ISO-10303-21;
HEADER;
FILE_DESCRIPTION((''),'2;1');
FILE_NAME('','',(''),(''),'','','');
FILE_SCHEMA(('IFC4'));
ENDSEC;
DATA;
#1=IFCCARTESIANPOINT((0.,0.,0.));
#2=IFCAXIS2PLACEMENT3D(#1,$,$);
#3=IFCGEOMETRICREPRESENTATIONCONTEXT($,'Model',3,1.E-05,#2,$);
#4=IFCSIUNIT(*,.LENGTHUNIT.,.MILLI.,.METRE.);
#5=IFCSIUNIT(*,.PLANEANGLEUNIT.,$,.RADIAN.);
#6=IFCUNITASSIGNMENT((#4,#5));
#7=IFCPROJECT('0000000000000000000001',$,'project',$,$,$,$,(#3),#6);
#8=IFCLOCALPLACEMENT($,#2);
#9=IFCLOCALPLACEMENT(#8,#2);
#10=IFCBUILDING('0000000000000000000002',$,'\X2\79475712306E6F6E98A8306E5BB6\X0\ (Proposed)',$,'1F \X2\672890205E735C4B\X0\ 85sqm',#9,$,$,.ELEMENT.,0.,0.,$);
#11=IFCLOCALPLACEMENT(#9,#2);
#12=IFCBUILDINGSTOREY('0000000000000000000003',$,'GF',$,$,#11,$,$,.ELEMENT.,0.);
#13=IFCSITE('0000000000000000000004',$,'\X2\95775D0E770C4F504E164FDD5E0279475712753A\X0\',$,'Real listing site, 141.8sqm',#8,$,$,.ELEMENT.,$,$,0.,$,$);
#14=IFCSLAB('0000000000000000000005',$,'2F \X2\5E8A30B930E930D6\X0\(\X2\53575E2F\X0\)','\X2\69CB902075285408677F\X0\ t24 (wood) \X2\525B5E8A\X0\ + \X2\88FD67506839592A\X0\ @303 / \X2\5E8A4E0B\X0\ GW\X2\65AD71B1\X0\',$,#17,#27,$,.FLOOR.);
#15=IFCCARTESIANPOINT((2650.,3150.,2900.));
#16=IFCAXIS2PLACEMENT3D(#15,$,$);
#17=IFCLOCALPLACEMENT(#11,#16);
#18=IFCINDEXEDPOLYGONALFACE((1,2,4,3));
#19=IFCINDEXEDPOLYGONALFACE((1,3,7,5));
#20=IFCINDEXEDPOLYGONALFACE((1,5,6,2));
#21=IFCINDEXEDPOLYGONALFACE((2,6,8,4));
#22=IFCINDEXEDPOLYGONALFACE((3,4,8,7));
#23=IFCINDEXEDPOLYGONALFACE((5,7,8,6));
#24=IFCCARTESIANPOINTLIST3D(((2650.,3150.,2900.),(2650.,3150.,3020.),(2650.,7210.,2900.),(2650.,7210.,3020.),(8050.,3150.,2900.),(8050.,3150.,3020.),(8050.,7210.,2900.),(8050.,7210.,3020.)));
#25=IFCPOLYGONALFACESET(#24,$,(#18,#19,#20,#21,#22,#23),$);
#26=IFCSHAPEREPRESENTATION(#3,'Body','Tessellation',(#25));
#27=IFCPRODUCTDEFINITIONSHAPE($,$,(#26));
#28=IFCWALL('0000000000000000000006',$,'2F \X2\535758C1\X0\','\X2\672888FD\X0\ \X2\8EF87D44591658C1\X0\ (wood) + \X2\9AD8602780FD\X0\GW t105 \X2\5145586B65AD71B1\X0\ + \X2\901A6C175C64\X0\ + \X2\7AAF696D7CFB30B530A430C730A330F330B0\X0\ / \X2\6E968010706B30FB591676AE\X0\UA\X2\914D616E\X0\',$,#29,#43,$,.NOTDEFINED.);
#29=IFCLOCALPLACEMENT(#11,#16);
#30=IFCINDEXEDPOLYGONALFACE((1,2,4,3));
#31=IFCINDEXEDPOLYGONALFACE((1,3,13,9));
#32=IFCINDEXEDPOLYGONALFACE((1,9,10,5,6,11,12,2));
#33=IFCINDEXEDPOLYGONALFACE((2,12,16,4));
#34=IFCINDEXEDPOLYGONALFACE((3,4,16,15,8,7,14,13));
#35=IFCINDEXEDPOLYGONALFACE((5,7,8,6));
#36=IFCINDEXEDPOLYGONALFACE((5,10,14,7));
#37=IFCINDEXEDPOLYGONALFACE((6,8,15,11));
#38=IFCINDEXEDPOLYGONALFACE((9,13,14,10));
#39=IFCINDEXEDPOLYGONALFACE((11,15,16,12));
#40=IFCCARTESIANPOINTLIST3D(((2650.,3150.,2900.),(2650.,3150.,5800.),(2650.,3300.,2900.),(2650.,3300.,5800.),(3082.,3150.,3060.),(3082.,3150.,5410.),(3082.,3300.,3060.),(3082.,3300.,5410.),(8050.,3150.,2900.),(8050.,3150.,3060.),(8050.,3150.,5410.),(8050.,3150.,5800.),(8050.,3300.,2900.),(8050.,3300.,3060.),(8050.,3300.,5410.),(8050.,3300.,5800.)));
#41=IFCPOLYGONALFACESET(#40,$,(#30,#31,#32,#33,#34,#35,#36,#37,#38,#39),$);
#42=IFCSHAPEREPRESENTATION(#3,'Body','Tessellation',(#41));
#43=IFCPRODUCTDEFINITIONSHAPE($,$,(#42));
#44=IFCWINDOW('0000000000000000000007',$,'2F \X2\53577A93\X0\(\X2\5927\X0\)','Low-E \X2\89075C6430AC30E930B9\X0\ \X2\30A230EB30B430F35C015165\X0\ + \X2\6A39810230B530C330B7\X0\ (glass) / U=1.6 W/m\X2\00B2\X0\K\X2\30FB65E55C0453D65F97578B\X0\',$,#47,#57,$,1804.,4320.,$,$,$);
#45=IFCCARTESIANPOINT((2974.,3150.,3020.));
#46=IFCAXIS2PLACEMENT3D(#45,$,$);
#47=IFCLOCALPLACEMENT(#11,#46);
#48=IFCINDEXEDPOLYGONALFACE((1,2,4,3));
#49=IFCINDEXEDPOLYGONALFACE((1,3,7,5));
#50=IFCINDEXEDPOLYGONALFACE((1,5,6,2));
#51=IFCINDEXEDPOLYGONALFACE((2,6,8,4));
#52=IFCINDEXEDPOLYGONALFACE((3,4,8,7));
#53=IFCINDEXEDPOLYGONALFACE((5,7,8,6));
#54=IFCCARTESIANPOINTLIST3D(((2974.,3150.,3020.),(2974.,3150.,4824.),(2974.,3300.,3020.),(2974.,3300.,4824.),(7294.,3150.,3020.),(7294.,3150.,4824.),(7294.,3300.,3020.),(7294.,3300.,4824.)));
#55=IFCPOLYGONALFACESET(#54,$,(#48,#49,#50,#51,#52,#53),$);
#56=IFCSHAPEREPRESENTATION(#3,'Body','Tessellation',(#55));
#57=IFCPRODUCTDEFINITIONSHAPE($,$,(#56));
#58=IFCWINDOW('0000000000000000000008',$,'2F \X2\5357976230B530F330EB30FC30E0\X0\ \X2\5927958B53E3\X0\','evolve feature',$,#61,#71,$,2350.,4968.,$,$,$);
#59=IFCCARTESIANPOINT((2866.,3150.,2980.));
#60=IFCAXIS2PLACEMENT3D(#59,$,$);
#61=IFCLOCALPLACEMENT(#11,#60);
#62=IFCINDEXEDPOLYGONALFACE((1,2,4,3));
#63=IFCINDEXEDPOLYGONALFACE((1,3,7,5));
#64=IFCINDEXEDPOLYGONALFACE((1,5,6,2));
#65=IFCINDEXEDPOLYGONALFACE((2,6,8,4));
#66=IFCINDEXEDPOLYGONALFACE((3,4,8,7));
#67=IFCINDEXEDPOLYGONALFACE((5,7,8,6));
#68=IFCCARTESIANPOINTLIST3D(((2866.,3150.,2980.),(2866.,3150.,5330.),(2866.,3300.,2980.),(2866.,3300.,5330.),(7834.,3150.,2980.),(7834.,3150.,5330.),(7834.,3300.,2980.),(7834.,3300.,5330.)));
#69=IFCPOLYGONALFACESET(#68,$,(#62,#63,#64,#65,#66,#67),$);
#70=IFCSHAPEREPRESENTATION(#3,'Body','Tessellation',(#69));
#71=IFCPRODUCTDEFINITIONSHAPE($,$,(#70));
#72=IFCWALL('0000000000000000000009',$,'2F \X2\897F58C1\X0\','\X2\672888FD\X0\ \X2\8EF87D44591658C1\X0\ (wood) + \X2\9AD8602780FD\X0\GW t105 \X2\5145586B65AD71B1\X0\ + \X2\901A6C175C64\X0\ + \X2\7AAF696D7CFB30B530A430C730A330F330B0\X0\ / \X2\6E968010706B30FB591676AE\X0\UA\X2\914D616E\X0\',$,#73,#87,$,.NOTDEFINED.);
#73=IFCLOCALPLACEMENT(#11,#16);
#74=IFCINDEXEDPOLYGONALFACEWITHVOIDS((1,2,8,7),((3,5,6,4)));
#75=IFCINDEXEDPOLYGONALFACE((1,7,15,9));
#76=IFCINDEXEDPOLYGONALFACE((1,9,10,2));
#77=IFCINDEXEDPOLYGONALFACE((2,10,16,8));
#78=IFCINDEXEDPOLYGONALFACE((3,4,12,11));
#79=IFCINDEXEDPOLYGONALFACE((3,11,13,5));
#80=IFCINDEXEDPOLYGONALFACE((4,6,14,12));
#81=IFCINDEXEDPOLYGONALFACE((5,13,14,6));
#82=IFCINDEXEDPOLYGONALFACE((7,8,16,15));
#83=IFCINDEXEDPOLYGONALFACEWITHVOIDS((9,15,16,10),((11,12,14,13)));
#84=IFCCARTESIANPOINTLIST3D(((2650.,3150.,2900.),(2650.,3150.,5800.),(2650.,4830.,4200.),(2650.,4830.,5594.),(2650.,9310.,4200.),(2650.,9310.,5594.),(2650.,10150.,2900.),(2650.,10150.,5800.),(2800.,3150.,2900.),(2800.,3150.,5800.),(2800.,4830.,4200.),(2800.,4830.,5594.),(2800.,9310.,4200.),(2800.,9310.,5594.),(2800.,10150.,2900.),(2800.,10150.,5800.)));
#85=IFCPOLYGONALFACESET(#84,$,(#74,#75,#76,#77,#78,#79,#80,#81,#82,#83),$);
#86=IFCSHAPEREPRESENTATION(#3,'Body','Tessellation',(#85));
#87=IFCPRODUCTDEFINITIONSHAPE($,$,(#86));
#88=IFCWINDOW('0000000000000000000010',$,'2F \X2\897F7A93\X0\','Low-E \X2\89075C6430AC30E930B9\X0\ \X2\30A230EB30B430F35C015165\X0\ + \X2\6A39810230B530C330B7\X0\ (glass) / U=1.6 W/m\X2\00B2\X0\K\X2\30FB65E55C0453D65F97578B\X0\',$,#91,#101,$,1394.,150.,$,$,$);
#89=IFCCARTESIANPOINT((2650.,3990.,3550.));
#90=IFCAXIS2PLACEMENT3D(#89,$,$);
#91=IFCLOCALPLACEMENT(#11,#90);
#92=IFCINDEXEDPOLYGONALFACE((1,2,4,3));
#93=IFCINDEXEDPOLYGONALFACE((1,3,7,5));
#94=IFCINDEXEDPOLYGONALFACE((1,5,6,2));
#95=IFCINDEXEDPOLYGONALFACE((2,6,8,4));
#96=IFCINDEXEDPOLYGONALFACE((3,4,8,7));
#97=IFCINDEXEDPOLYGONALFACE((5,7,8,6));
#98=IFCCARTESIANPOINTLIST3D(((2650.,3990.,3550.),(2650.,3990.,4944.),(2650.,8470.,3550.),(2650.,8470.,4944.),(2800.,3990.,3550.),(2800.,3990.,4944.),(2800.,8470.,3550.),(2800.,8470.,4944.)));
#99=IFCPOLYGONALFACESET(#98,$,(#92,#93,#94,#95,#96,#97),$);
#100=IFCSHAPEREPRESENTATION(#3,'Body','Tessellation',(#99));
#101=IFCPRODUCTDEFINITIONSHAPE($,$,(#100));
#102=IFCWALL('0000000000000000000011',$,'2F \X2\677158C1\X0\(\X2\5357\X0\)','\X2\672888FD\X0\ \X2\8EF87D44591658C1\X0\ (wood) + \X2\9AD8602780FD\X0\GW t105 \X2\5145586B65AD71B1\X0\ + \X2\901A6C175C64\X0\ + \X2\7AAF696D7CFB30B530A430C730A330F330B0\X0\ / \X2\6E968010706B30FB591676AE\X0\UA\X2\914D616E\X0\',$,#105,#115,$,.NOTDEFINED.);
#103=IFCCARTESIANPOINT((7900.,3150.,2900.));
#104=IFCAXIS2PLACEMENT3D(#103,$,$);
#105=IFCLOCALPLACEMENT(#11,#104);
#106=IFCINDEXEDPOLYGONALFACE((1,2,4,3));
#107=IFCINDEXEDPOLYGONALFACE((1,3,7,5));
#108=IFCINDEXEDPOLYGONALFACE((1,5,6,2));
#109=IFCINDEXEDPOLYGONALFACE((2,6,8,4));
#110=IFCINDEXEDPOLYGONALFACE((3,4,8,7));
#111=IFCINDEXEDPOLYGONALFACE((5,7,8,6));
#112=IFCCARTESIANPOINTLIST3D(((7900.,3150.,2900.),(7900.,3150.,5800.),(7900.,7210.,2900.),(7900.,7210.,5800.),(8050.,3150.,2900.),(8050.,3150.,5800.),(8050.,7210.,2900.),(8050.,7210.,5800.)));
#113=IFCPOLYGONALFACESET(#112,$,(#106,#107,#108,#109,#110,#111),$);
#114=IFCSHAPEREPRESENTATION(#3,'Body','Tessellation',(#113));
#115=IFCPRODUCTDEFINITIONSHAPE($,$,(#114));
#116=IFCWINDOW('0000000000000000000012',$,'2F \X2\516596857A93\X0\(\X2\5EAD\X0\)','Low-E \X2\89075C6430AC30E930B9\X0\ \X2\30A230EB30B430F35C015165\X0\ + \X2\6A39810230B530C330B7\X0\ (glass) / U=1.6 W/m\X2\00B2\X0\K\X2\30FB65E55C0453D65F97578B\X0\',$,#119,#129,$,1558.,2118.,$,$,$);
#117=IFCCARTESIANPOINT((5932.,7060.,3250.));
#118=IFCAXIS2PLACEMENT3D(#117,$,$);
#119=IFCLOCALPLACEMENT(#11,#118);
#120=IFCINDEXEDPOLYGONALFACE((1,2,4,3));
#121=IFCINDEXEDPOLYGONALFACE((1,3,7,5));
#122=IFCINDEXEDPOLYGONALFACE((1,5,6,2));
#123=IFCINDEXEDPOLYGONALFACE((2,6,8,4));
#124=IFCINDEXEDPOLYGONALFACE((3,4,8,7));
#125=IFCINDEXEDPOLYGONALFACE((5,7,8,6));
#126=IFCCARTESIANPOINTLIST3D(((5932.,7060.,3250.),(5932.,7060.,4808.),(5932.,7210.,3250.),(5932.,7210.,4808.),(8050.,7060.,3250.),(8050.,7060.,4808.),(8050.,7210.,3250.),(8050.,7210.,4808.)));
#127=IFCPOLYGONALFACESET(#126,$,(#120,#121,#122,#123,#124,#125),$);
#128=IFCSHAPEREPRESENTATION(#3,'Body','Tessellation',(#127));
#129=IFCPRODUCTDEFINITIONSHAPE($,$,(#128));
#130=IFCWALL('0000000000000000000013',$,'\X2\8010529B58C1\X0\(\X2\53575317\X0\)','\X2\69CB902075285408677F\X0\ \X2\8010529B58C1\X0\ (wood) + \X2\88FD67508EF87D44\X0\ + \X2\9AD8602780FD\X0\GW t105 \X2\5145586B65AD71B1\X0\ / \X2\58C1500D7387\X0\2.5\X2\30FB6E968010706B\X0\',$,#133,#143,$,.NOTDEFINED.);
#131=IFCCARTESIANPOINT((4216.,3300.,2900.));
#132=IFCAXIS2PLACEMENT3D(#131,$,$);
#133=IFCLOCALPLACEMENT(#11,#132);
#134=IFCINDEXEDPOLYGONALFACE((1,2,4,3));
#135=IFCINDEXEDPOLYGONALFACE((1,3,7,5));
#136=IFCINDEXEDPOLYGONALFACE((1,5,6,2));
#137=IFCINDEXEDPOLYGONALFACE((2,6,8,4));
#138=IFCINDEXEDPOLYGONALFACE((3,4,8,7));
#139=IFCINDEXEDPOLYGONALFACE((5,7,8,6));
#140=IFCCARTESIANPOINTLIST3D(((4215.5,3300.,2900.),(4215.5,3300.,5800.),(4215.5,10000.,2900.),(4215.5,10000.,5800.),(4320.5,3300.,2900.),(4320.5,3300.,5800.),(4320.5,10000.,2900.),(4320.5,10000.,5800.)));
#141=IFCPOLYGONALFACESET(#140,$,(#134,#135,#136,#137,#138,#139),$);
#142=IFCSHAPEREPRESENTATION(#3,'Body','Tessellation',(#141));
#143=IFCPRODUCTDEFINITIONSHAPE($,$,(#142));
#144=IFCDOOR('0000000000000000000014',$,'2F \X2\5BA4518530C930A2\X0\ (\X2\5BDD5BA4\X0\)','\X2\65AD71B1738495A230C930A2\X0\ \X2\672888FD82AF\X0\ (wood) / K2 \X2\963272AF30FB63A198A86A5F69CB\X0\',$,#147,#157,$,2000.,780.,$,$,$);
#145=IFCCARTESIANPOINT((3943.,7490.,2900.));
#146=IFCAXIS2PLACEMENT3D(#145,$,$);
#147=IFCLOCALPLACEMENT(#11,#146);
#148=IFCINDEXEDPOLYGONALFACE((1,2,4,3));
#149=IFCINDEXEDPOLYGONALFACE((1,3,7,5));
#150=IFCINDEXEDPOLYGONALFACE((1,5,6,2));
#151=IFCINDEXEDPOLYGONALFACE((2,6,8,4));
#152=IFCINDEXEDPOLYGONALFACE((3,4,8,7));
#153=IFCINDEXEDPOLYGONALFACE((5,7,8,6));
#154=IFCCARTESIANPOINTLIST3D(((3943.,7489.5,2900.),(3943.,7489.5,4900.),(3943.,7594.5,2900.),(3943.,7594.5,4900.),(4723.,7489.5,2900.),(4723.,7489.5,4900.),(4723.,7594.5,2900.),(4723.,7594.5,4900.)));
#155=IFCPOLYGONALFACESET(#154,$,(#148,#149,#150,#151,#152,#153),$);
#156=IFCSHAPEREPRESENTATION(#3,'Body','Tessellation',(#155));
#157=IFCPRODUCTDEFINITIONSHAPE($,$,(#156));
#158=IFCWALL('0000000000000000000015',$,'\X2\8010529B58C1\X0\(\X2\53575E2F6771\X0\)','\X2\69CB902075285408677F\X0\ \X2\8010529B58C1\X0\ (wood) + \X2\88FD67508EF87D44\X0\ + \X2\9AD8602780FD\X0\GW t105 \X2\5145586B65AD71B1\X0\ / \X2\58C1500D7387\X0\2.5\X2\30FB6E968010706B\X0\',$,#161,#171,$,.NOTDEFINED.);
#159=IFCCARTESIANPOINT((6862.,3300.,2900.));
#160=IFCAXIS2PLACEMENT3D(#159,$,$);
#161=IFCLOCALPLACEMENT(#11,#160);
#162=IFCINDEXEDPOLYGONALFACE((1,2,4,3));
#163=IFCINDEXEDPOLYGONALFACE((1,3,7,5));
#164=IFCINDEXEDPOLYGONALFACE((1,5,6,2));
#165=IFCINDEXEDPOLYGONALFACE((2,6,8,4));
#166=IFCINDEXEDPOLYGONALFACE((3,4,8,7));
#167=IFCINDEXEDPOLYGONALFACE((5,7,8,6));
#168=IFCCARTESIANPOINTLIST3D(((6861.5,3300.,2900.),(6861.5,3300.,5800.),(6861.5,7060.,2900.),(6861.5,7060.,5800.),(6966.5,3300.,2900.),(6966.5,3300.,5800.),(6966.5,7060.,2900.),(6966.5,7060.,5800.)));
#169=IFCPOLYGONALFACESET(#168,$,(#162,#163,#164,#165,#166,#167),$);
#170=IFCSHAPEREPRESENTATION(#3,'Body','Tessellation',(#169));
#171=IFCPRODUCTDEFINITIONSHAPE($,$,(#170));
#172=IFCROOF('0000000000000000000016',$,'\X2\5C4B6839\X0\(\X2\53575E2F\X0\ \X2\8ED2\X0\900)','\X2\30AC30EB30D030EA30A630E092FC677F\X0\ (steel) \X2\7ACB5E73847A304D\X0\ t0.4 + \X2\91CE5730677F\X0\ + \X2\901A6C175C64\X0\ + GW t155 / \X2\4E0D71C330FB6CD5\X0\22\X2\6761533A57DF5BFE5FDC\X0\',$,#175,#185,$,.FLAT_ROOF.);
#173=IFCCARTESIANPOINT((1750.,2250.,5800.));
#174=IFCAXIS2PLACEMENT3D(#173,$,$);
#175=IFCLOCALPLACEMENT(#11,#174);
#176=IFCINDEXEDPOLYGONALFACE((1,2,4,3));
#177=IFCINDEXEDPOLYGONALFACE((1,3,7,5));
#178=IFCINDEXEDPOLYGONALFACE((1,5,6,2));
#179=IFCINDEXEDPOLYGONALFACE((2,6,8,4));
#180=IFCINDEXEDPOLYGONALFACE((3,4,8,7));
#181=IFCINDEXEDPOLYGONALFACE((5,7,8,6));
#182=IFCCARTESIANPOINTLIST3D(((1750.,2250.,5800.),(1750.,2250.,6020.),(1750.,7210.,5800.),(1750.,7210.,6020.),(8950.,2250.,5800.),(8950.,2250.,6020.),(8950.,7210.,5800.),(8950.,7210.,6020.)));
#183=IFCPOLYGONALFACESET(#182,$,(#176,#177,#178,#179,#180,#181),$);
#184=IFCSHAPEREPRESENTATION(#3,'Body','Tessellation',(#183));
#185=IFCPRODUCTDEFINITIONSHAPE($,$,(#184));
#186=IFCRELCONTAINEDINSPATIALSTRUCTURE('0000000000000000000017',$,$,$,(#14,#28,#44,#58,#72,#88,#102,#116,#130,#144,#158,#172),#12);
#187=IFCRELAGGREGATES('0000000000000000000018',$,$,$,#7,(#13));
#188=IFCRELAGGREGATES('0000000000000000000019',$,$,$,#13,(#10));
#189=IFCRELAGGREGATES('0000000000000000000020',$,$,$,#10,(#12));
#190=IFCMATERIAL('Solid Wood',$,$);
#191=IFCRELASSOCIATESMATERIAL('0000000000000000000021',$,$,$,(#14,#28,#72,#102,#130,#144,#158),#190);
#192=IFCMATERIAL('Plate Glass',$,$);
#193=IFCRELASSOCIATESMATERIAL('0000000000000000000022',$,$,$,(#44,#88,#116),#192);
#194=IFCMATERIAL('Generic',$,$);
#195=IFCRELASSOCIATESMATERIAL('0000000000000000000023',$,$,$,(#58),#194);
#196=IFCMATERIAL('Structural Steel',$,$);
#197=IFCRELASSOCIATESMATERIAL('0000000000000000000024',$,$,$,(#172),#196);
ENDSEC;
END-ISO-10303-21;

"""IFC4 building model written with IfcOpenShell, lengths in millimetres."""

from ifc_helpers import new_model, si_unit, frame, frame_2d, origin, place, context, project, spatial, rectangle, extrude, material, element, fill, save


model = new_model("IFC4")

# Units and contexts
model_context = context("Model", 3, precision=1e-05, world=origin())
ifc_project = project(units=[si_unit("LENGTHUNIT", "METRE", prefix="MILLI"), si_unit("PLANEANGLEUNIT", "RADIAN")], contexts=[model_context])

# Site, building, storey
site_placement = place(None, origin())
site = spatial("IfcSite", under=ifc_project, at=site_placement, Name="長崎県佐世保市祇園町", ObjectType="Real listing site, 141.8sqm", CompositionType="ELEMENT", RefElevation=0.0)
building_placement = place(site_placement, origin())
building = spatial("IfcBuilding", under=site, at=building_placement, Name="祇園の潮風の家 (Proposed)", ObjectType="1F 木造平屋 85sqm", CompositionType="ELEMENT", ElevationOfRefHeight=0.0, ElevationOfTerrain=0.0)
storey_placement = place(building_placement, origin())
storey = spatial("IfcBuildingStorey", under=building, at=storey_placement, Name="GF", CompositionType="ELEMENT", Elevation=0.0)

# Slab
ifc_material_1 = material(Name="Solid Wood")
slab_placement = place(storey_placement, frame((2650.0, 3150.0, 2900.0)))
element("IfcSlab", 1, at=slab_placement, inside=storey, material=ifc_material_1, Name="2F 床スラブ(南帯)", Description="構造用合板 t24 (wood) 剛床 + 製材根太 @303 / 床下 GW断熱", PredefinedType="FLOOR", context=model_context, shape_type="SweptSolid", body=[
    extrude(rectangle(XDim=5400.0, YDim=4060.0, at=frame_2d((2700.0, 2030.0))), frame((2650.0, 3150.0, 2900.0)), (0.0, 0.0, 1.0), 120.0),
])

# Wall, openings, windows
wall_1_placement = place(storey_placement, frame((2650.0, 3150.0, 2900.0)))
wall_1 = element("IfcWall", 2, at=wall_1_placement, inside=storey, material=ifc_material_1, Name="2F 南壁", Description="木製 軸組外壁 (wood) + 高性能GW t105 充填断熱 + 通気層 + 窯業系サイディング / 準耐火・外皮UA配慮", PredefinedType="NOTDEFINED", context=model_context, shape_type="SweptSolid", body=[
    extrude(rectangle(XDim=5400.0, YDim=150.0, at=frame_2d((2700.0, 75.0))), frame((2650.0, 3150.0, 2900.0)), (0.0, 0.0, 1.0), 2900.0),
])
opening_1_placement = place(storey_placement, frame((2974.0, 3150.0, 3020.0)))
opening_1 = element("IfcOpeningElement", 3, at=opening_1_placement, cuts=wall_1, PredefinedType="NOTDEFINED", context=model_context, shape_type="SweptSolid", body=[
    extrude(rectangle(XDim=4320.0, YDim=150.0, at=frame_2d((2160.0, 75.0))), frame((2974.0, 3150.0, 3020.0)), (0.0, 0.0, 1.0), 1804.0),
])
opening_2_placement = place(storey_placement, frame((2866.0, 3150.0, 2980.0)))
opening_2 = element("IfcOpeningElement", 4, at=opening_2_placement, cuts=wall_1, PredefinedType="NOTDEFINED", context=model_context, shape_type="SweptSolid", body=[
    extrude(rectangle(XDim=4968.0, YDim=150.0, at=frame_2d((2484.0, 75.0))), frame((2866.0, 3150.0, 2980.0)), (0.0, 0.0, 1.0), 2350.0),
])
ifc_material_2 = material(Name="Plate Glass")
window_1_placement = place(storey_placement, frame((2974.0, 3150.0, 3020.0)))
window_1 = element("IfcWindow", 5, at=window_1_placement, inside=storey, material=ifc_material_2, Name="2F 南窓(大)", Description="Low-E 複層ガラス アルゴン封入 + 樹脂サッシ (glass) / U=1.6 W/m²K・日射取得型", OverallHeight=1804.0, OverallWidth=4320.0, context=model_context, shape_type="SweptSolid", body=[
    extrude(rectangle(XDim=4320.0, YDim=150.0, at=frame_2d((2160.0, 75.0))), frame((2974.0, 3150.0, 3020.0)), (0.0, 0.0, 1.0), 1804.0),
])
fill(opening_1, window_1)
ifc_material_3 = material(Name="Generic")
window_2_placement = place(storey_placement, frame((2866.0, 3150.0, 2980.0)))
window_2 = element("IfcWindow", 6, at=window_2_placement, inside=storey, material=ifc_material_3, Name="2F 南面サンルーム 大開口", Description="evolve feature", OverallHeight=2350.0, OverallWidth=4968.0, context=model_context, shape_type="SweptSolid", body=[
    extrude(rectangle(XDim=4968.0, YDim=150.0, at=frame_2d((2484.0, 75.0))), frame((2866.0, 3150.0, 2980.0)), (0.0, 0.0, 1.0), 2350.0),
])
fill(opening_2, window_2)

# Walls, openings, windows
wall_2_placement = place(storey_placement, frame((2650.0, 3150.0, 2900.0)))
wall_2 = element("IfcWall", 7, at=wall_2_placement, inside=storey, material=ifc_material_1, Name="2F 西壁", Description="木製 軸組外壁 (wood) + 高性能GW t105 充填断熱 + 通気層 + 窯業系サイディング / 準耐火・外皮UA配慮", PredefinedType="NOTDEFINED", context=model_context, shape_type="SweptSolid", body=[
    extrude(rectangle(XDim=150.0, YDim=7000.0, at=frame_2d((75.0, 3500.0))), frame((2650.0, 3150.0, 2900.0)), (0.0, 0.0, 1.0), 2900.0),
])
opening_3_placement = place(storey_placement, frame((2650.0, 3990.0, 3550.0)))
opening_3 = element("IfcOpeningElement", 8, at=opening_3_placement, cuts=wall_2, PredefinedType="NOTDEFINED", context=model_context, shape_type="SweptSolid", body=[
    extrude(rectangle(XDim=150.0, YDim=4480.0, at=frame_2d((75.0, 2240.0))), frame((2650.0, 3990.0, 3550.0)), (0.0, 0.0, 1.0), 1394.0),
])
window_3_placement = place(storey_placement, frame((2650.0, 3990.0, 3550.0)))
window_3 = element("IfcWindow", 9, at=window_3_placement, inside=storey, material=ifc_material_2, Name="2F 西窓", Description="Low-E 複層ガラス アルゴン封入 + 樹脂サッシ (glass) / U=1.6 W/m²K・日射取得型", OverallHeight=1394.0, OverallWidth=150.0, context=model_context, shape_type="SweptSolid", body=[
    extrude(rectangle(XDim=150.0, YDim=4480.0, at=frame_2d((75.0, 2240.0))), frame((2650.0, 3990.0, 3550.0)), (0.0, 0.0, 1.0), 1394.0),
])
fill(opening_3, window_3)
wall_3_placement = place(storey_placement, frame((7900.0, 3150.0, 2900.0)))
wall_3 = element("IfcWall", 10, at=wall_3_placement, inside=storey, material=ifc_material_1, Name="2F 東壁(南)", Description="木製 軸組外壁 (wood) + 高性能GW t105 充填断熱 + 通気層 + 窯業系サイディング / 準耐火・外皮UA配慮", PredefinedType="NOTDEFINED", context=model_context, shape_type="SweptSolid", body=[
    extrude(rectangle(XDim=150.0, YDim=4060.0, at=frame_2d((75.0, 2030.0))), frame((7900.0, 3150.0, 2900.0)), (0.0, 0.0, 1.0), 2900.0),
])
opening_4_placement = place(storey_placement, frame((5932.0, 7060.0, 3250.0)))
opening_4 = element("IfcOpeningElement", 11, at=opening_4_placement, cuts=wall_3, PredefinedType="NOTDEFINED", context=model_context, shape_type="SweptSolid", body=[
    extrude(rectangle(XDim=2118.0, YDim=150.0, at=frame_2d((1059.0, 75.0))), frame((5932.0, 7060.0, 3250.0)), (0.0, 0.0, 1.0), 1558.0),
])
window_4_placement = place(storey_placement, frame((5932.0, 7060.0, 3250.0)))
window_4 = element("IfcWindow", 12, at=window_4_placement, inside=storey, material=ifc_material_2, Name="2F 入隅窓(庭)", Description="Low-E 複層ガラス アルゴン封入 + 樹脂サッシ (glass) / U=1.6 W/m²K・日射取得型", OverallHeight=1558.0, OverallWidth=2118.0, context=model_context, shape_type="SweptSolid", body=[
    extrude(rectangle(XDim=2118.0, YDim=150.0, at=frame_2d((1059.0, 75.0))), frame((5932.0, 7060.0, 3250.0)), (0.0, 0.0, 1.0), 1558.0),
])
fill(opening_4, window_4)

# Wall, opening, door
wall_4_placement = place(storey_placement, frame((4216.0, 3300.0, 2900.0)))
wall_4 = element("IfcWall", 13, at=wall_4_placement, inside=storey, material=ifc_material_1, Name="耐力壁(南北)", Description="構造用合板 耐力壁 (wood) + 製材軸組 + 高性能GW t105 充填断熱 / 壁倍率2.5・準耐火", PredefinedType="NOTDEFINED", context=model_context, shape_type="SweptSolid", body=[
    extrude(rectangle(XDim=105.0, YDim=6700.0, at=frame_2d((52.0, 3350.0))), frame((4216.0, 3300.0, 2900.0)), (0.0, 0.0, 1.0), 2900.0),
])
opening_5_placement = place(storey_placement, frame((3943.0, 7490.0, 2900.0)))
opening_5 = element("IfcOpeningElement", 14, at=opening_5_placement, cuts=wall_4, PredefinedType="NOTDEFINED", context=model_context, shape_type="SweptSolid", body=[
    extrude(rectangle(XDim=780.0, YDim=105.0, at=frame_2d((390.0, 52.0))), frame((3943.0, 7490.0, 2900.0)), (0.0, 0.0, 1.0), 2000.0),
])
door_placement = place(storey_placement, frame((3943.0, 7490.0, 2900.0)))
door = element("IfcDoor", 15, at=door_placement, inside=storey, material=ifc_material_1, Name="2F 室内ドア (寝室)", Description="断熱玄関ドア 木製芯 (wood) / K2 防犯・採風機構", OverallHeight=2000.0, OverallWidth=780.0, context=model_context, shape_type="SweptSolid", body=[
    extrude(rectangle(XDim=780.0, YDim=105.0, at=frame_2d((390.0, 52.0))), frame((3943.0, 7490.0, 2900.0)), (0.0, 0.0, 1.0), 2000.0),
])
fill(opening_5, door)

# Wall
wall_5_placement = place(storey_placement, frame((6862.0, 3300.0, 2900.0)))
element("IfcWall", 16, at=wall_5_placement, inside=storey, material=ifc_material_1, Name="耐力壁(南帯東)", Description="構造用合板 耐力壁 (wood) + 製材軸組 + 高性能GW t105 充填断熱 / 壁倍率2.5・準耐火", PredefinedType="NOTDEFINED", context=model_context, shape_type="SweptSolid", body=[
    extrude(rectangle(XDim=105.0, YDim=3760.0, at=frame_2d((52.0, 1880.0))), frame((6862.0, 3300.0, 2900.0)), (0.0, 0.0, 1.0), 2900.0),
])

# Roof
ifc_material_4 = material(Name="Structural Steel")
for number, where, name in (
    (17, (1750.0, 2250.0, 5800.0), "屋根(南帯 軒900)"),
):
    element("IfcRoof", number, at=place(storey_placement, frame(where)), inside=storey, material=ifc_material_4, Name=name, Description="ガルバリウム鋼板 (steel) 立平葺き t0.4 + 野地板 + 通気層 + GW t155 / 不燃・法22条区域対応", PredefinedType="FLAT_ROOF", context=model_context, shape_type="SweptSolid", body=[
        extrude(rectangle(XDim=7200.0, YDim=4960.0, at=frame_2d((3600.0, 2480.0))), frame((1750.0, 2250.0, 5800.0)), (0.0, 0.0, 1.0), 220.0),
    ])

save(model, "model.ifc")
